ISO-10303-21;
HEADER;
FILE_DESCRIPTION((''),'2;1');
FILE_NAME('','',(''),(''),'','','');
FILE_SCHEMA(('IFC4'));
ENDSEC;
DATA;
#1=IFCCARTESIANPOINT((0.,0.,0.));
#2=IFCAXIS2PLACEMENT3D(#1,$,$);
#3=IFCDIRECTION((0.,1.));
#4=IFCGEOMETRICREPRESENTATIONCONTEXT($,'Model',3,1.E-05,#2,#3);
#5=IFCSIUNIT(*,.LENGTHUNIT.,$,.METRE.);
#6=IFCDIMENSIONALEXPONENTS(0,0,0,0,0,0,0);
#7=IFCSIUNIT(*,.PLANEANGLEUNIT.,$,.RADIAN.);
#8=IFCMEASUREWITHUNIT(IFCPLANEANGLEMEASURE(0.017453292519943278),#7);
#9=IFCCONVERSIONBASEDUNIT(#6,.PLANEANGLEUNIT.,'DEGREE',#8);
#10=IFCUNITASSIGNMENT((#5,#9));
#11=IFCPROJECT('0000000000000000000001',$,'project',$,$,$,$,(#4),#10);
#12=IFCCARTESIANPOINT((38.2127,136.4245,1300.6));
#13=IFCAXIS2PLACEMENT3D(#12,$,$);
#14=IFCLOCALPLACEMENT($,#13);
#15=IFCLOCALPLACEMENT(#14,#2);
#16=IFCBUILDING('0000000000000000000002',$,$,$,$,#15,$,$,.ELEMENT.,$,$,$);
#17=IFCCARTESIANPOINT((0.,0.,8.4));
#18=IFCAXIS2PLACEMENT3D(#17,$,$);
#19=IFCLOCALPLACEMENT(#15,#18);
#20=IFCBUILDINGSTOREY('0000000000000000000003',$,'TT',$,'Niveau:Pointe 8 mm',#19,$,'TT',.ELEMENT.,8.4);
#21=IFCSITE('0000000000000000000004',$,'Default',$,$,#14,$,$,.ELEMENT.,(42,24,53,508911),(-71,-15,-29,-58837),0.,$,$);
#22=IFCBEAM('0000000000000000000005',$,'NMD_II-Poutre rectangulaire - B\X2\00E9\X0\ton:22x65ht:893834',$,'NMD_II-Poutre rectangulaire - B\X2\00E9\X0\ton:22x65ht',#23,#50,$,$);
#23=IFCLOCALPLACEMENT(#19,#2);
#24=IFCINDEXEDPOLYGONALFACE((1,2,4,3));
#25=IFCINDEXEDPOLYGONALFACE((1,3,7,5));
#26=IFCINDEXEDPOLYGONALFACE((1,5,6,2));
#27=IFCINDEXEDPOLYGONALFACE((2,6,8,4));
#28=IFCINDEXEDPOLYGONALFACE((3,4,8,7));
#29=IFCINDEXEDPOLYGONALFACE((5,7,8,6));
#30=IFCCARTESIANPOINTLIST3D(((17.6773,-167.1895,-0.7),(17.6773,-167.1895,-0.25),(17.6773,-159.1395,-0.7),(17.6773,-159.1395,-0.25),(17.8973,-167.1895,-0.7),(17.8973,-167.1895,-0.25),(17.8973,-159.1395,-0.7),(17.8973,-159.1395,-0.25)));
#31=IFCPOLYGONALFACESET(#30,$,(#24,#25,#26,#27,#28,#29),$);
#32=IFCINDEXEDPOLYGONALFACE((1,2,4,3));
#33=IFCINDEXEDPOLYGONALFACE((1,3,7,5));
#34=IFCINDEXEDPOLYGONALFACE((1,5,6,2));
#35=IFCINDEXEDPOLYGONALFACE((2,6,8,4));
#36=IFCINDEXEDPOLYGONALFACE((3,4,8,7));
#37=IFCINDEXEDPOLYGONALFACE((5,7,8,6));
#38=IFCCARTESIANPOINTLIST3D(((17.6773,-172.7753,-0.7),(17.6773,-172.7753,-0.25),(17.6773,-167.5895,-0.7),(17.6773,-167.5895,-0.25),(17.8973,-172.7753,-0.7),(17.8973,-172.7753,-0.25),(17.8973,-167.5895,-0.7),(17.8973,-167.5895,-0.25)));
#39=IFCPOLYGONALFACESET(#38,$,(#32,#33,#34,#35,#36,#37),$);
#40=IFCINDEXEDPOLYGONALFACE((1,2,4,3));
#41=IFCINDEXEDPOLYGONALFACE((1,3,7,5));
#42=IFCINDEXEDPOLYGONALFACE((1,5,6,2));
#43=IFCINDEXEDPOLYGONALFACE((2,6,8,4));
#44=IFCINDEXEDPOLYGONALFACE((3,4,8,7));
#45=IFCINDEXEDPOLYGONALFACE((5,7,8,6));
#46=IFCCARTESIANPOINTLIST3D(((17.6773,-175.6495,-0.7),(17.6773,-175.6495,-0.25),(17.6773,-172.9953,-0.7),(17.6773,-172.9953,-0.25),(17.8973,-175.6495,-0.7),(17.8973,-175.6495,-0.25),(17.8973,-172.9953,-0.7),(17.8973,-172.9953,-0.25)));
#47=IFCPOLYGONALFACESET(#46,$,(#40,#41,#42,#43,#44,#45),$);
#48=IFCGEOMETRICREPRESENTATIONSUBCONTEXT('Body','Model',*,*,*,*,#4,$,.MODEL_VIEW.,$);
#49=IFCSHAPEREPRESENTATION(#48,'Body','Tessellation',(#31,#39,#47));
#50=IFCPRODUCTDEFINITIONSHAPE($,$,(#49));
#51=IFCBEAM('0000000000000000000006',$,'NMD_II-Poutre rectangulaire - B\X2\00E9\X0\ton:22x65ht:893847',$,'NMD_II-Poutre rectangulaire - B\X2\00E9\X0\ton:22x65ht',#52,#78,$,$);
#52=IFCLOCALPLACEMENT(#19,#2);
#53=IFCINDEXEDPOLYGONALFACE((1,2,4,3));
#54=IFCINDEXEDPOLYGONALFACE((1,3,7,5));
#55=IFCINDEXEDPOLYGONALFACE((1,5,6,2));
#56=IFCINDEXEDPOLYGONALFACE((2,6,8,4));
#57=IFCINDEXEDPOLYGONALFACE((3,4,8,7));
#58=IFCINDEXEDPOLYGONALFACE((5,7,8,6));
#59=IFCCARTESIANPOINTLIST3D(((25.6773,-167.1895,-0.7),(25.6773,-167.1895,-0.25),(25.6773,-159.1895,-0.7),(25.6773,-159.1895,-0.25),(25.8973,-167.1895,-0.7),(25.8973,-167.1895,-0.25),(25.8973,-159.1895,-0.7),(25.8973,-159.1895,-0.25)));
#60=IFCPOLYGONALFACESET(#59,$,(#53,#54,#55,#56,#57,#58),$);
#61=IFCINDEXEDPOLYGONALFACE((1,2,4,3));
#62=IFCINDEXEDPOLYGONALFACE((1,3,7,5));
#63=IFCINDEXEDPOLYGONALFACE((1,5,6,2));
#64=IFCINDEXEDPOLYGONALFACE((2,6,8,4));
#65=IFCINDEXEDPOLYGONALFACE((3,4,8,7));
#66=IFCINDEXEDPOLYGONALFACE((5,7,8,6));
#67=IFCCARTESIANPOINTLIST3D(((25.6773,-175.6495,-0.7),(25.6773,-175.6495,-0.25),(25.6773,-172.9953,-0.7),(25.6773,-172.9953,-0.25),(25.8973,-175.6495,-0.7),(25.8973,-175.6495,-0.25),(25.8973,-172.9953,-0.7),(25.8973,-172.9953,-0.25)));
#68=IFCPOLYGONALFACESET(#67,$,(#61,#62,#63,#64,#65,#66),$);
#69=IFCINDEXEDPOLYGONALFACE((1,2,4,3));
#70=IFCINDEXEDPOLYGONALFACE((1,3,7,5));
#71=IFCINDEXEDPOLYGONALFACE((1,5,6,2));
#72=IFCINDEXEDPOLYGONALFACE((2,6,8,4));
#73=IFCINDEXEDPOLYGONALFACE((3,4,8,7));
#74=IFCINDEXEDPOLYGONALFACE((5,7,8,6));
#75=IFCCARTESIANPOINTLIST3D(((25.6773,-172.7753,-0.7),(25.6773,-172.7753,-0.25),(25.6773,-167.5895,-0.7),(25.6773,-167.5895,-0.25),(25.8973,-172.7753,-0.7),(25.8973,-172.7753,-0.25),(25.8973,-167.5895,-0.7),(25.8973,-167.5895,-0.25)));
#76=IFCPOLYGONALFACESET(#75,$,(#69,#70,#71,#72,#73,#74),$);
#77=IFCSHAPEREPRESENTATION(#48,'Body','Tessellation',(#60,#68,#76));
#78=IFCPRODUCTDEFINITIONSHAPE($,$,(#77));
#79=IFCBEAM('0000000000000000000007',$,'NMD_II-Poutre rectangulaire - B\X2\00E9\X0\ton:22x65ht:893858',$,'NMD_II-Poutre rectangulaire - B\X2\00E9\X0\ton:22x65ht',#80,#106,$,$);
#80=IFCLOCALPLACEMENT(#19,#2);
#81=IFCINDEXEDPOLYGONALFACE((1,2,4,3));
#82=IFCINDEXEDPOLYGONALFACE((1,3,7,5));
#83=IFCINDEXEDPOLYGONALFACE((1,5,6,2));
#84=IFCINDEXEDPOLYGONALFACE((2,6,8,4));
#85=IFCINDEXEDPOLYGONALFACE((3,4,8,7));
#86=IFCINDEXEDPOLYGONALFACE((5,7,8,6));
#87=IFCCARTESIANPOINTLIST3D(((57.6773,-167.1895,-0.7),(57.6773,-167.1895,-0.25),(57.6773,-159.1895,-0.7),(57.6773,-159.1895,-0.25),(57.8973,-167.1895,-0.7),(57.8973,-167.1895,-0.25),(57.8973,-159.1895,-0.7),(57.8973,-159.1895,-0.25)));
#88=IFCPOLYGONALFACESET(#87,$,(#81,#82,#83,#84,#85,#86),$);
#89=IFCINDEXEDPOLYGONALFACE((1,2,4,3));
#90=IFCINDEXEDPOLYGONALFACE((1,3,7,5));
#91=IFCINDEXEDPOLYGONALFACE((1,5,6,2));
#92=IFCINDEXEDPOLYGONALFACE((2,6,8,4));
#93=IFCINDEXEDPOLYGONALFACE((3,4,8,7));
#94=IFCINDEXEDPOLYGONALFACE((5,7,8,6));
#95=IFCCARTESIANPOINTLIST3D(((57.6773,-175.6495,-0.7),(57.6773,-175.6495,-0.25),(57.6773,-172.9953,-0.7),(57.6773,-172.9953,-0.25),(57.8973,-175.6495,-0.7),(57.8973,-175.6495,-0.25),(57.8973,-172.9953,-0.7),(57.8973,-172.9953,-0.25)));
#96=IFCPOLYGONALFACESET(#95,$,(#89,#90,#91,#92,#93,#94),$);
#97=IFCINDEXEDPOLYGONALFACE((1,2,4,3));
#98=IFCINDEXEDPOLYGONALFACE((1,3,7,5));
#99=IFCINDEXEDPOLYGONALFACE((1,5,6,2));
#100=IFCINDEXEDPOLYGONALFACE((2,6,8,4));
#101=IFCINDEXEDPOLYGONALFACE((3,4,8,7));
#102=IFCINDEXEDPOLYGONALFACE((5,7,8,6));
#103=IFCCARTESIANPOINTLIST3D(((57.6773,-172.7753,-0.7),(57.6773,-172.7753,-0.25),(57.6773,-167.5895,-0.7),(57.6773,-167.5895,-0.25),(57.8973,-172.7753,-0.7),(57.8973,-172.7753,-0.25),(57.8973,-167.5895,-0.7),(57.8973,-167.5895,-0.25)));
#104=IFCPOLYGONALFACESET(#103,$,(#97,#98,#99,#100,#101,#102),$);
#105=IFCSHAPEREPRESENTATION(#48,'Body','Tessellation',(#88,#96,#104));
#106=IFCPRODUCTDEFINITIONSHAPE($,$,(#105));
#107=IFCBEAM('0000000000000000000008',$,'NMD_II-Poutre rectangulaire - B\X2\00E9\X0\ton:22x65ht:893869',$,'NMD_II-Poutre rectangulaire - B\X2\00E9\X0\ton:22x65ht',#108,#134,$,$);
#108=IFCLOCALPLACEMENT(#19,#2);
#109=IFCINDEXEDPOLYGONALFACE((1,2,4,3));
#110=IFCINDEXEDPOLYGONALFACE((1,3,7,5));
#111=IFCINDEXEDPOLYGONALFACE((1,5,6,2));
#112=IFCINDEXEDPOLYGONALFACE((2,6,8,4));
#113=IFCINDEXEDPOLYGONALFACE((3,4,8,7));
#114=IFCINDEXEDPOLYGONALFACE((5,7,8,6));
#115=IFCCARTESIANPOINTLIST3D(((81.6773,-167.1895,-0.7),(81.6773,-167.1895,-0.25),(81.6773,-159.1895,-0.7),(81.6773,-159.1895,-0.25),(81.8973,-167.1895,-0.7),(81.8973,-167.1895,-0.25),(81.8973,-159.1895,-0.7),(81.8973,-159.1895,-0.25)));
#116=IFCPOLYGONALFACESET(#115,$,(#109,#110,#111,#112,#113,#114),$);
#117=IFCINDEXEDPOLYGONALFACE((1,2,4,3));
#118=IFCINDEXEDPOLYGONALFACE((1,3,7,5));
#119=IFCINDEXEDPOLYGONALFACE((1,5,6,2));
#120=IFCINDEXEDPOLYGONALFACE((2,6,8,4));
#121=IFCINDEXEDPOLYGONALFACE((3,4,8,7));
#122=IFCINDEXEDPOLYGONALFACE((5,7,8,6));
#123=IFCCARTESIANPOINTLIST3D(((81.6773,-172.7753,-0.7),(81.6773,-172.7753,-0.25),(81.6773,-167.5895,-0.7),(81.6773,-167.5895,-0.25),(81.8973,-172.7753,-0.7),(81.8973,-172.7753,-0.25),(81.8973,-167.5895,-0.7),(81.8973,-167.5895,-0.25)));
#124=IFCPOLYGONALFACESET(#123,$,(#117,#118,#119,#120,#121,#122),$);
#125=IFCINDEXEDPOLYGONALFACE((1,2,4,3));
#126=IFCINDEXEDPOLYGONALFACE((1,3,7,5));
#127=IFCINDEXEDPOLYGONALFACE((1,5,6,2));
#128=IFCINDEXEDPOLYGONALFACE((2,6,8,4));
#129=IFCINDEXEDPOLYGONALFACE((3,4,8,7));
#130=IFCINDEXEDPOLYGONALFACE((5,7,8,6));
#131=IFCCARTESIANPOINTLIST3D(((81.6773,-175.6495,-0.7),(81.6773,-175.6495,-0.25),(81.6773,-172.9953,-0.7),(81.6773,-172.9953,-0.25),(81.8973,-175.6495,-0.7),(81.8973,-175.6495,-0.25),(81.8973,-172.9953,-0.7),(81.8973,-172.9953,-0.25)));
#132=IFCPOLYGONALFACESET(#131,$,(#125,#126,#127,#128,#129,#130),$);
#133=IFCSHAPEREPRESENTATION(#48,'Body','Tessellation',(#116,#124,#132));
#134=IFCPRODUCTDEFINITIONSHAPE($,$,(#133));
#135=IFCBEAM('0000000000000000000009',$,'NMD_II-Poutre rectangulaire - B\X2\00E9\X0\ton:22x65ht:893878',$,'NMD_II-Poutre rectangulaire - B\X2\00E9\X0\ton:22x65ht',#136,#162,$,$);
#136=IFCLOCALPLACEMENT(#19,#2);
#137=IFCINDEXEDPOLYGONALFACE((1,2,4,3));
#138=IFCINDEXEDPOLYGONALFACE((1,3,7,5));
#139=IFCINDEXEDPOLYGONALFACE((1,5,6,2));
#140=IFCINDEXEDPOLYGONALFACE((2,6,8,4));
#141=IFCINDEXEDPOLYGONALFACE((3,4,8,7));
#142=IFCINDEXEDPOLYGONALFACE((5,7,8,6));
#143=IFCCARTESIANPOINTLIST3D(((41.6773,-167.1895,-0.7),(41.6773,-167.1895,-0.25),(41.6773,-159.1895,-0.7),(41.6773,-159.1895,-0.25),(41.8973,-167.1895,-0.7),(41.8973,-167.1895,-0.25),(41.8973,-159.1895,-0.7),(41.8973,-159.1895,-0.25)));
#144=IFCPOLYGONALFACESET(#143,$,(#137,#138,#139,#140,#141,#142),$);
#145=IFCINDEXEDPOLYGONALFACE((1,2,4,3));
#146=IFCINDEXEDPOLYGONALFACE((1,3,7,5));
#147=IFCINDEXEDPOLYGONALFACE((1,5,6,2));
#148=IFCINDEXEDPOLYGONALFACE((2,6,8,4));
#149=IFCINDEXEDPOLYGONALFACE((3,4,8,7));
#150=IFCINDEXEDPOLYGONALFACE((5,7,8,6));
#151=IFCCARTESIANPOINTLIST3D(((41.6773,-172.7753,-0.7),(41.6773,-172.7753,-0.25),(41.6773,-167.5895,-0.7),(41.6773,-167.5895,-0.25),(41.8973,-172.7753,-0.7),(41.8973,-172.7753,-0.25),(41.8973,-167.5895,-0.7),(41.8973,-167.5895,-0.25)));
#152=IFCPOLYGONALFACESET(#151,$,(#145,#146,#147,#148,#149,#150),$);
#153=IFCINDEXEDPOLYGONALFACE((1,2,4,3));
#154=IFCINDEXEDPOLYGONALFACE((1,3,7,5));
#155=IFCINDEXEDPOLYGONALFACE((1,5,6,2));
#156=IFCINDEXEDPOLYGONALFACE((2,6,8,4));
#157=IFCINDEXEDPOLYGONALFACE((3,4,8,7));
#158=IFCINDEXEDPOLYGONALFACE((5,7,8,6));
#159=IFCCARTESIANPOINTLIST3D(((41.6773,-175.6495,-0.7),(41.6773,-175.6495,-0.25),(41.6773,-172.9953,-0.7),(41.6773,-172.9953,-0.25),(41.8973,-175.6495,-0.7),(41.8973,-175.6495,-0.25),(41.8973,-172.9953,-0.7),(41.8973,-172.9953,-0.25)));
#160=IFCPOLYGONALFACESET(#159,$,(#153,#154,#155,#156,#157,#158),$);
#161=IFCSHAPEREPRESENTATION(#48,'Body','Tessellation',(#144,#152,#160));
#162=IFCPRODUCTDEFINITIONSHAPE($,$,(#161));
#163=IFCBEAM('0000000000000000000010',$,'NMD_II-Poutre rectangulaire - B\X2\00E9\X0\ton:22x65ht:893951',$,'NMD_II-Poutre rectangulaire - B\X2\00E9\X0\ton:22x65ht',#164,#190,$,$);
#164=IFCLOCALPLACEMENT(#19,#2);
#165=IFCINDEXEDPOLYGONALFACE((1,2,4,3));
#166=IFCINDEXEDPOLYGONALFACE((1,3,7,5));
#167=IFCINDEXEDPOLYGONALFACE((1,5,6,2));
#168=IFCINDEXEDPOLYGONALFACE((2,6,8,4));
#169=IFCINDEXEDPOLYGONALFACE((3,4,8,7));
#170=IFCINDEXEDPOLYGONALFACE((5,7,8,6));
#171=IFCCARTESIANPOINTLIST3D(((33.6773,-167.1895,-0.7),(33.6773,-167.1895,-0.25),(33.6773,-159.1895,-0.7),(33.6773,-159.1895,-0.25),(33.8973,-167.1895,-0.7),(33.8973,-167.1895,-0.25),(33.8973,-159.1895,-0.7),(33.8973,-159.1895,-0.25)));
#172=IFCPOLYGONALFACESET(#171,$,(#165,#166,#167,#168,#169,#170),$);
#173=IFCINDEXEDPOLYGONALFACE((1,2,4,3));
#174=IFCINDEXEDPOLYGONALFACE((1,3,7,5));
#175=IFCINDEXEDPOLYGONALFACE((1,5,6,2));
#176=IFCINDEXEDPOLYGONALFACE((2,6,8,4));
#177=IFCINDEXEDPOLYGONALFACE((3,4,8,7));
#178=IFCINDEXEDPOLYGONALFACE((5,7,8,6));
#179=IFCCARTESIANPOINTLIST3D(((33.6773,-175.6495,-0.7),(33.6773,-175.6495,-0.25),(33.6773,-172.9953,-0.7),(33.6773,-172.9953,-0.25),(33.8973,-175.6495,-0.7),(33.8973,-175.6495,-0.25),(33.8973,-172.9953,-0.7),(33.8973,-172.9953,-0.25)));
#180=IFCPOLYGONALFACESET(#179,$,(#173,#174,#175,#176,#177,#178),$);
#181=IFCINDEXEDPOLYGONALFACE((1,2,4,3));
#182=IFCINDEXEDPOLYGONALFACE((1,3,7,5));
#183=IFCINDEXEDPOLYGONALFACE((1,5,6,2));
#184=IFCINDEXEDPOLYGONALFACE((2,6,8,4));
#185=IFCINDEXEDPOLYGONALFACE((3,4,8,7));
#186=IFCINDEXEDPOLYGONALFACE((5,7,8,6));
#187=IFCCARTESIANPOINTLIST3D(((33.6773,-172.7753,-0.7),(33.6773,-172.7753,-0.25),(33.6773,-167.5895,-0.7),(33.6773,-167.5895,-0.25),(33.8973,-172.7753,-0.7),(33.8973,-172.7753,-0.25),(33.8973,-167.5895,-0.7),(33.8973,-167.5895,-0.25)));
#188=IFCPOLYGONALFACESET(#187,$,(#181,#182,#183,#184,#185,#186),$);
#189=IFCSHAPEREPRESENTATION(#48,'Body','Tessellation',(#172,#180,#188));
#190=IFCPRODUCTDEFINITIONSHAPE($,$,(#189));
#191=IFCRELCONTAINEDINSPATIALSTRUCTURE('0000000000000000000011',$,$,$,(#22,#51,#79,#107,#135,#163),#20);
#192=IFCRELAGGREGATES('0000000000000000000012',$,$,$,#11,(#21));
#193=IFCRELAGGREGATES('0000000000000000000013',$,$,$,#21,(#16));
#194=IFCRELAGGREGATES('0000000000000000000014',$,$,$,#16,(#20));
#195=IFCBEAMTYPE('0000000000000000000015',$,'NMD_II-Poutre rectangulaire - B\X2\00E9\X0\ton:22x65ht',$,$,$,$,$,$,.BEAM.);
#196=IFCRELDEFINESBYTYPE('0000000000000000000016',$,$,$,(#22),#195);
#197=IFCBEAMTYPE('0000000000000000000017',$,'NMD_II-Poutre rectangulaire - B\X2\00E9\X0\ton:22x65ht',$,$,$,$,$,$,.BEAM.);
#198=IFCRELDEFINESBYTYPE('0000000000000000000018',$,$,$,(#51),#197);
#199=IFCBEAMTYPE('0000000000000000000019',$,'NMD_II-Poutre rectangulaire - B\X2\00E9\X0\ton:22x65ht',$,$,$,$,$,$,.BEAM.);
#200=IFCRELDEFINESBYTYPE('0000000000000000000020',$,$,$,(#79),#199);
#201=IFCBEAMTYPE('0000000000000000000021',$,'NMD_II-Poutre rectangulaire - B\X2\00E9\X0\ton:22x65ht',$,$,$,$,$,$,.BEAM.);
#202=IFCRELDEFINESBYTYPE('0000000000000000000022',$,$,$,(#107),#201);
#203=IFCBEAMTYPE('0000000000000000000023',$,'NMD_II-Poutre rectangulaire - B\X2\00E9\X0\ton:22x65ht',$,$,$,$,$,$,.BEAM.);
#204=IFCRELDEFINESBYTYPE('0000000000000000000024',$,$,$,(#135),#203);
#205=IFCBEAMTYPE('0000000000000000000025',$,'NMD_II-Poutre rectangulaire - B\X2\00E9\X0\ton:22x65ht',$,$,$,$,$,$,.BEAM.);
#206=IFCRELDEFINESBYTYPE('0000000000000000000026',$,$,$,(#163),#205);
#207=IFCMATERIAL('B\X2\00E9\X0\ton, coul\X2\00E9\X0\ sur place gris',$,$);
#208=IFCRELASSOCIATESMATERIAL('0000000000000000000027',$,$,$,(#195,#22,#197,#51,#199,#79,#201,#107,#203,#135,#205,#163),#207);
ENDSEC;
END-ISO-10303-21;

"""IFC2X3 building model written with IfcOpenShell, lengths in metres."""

from ifc_helpers import new_model, entity, si_unit, converted_unit, direction, frame, frame_2d, origin, place, context, subcontext, project, spatial, rectangle, extrude, source, transform, mapped, material, type_object, type_shapes, element, save


model = new_model("IFC2X3")

# Units and contexts
model_context = context("Model", 3, precision=1e-05, world=origin(), true_north=direction((0.0, 1.0)))
body_context = subcontext(model_context, "Body", "Model", "MODEL_VIEW")
ifc_project = project(units=[si_unit("LENGTHUNIT", "METRE"), converted_unit("PLANEANGLEUNIT", "DEGREE", entity("IfcPlaneAngleMeasure", 0.017453292519943278), si_unit("PLANEANGLEUNIT", "RADIAN"), dimensions=[0, 0, 0, 0, 0, 0, 0])], contexts=[model_context])

# Site, building, storey
site_placement = place(None, frame((38.2127, 136.4245, 1300.6)))
site = spatial("IfcSite", under=ifc_project, at=site_placement, Name="Default", CompositionType="ELEMENT", RefLatitude=(42, 24, 53, 508911), RefLongitude=(-71, -15, -29, -58837), RefElevation=0.0)
building_placement = place(site_placement, origin())
building = spatial("IfcBuilding", under=site, at=building_placement, CompositionType="ELEMENT")
storey_placement = place(building_placement, frame((0.0, 0.0, 8.4)))
storey = spatial("IfcBuildingStorey", under=building, at=storey_placement, Name="TT", ObjectType="Niveau:Pointe 8 mm", LongName="TT", CompositionType="ELEMENT", Elevation=8.4)

# Beams
ifc_material_1 = material(Name="Béton, coulé sur place gris")
beam_type_1 = type_object("IfcBeamType", Name="NMD_II-Poutre rectangulaire - Béton:22x65ht", PredefinedType="BEAM", material=ifc_material_1)
shared_shape_1 = source(origin(), body_context, "Body", "SweptSolid", [
    extrude(rectangle(XDim=0.45, YDim=0.22, at=frame_2d((0.0, 0.0), x_axis=(0.0, 1.0))), frame((17.7873, -167.1895, 7.925), z_axis=(0.0, 1.0, 0.0), x_axis=(-1.0, 0.0, 0.0)), (0.0, 0.0, 1.0), 8.05),
    extrude(rectangle(XDim=0.45, YDim=0.22, at=frame_2d((0.0, 0.0), x_axis=(0.0, 1.0))), frame((17.7873, -172.7753, 7.925), z_axis=(0.0, 1.0, 0.0), x_axis=(-1.0, 0.0, 0.0)), (0.0, 0.0, 1.0), 5.1859),
    extrude(rectangle(XDim=0.45, YDim=0.22, at=frame_2d((0.0, 0.0), x_axis=(0.0, 1.0))), frame((17.7873, -175.6495, 7.925), z_axis=(0.0, 1.0, 0.0), x_axis=(-1.0, 0.0, 0.0)), (0.0, 0.0, 1.0), 2.6541),
])
type_shapes(beam_type_1, [shared_shape_1])
beam_1_placement = place(storey_placement, frame((0.0, 0.0, -8.4)))
element("IfcBeam", 1, at=beam_1_placement, inside=storey, type_object=beam_type_1, material=ifc_material_1, Name="NMD_II-Poutre rectangulaire - Béton:22x65ht:893834", ObjectType="NMD_II-Poutre rectangulaire - Béton:22x65ht", context=body_context, shape_type="MappedRepresentation", body=[
    mapped(shared_shape_1, transform((0.0, 0.0, 0.0), scale=1.0)),
])
beam_type_2 = type_object("IfcBeamType", Name="NMD_II-Poutre rectangulaire - Béton:22x65ht", PredefinedType="BEAM", material=ifc_material_1)
shared_shape_2 = source(origin(), body_context, "Body", "SweptSolid", [
    extrude(rectangle(XDim=0.45, YDim=0.22, at=frame_2d((0.0, 0.0), x_axis=(0.0, 1.0))), frame((25.7873, -167.1895, 7.925), z_axis=(0.0, 1.0, 0.0), x_axis=(-1.0, 0.0, 0.0)), (0.0, 0.0, 1.0), 8.0),
    extrude(rectangle(XDim=0.45, YDim=0.22, at=frame_2d((0.0, 0.0), x_axis=(0.0, 1.0))), frame((25.7873, -175.6495, 7.925), z_axis=(0.0, 1.0, 0.0), x_axis=(-1.0, 0.0, 0.0)), (0.0, 0.0, 1.0), 2.6541),
    extrude(rectangle(XDim=0.45, YDim=0.22, at=frame_2d((0.0, 0.0), x_axis=(0.0, 1.0))), frame((25.7873, -172.7753, 7.925), z_axis=(0.0, 1.0, 0.0), x_axis=(-1.0, 0.0, 0.0)), (0.0, 0.0, 1.0), 5.1859),
])
type_shapes(beam_type_2, [shared_shape_2])
beam_2_placement = place(storey_placement, frame((0.0, 0.0, -8.4)))
element("IfcBeam", 2, at=beam_2_placement, inside=storey, type_object=beam_type_2, material=ifc_material_1, Name="NMD_II-Poutre rectangulaire - Béton:22x65ht:893847", ObjectType="NMD_II-Poutre rectangulaire - Béton:22x65ht", context=body_context, shape_type="MappedRepresentation", body=[
    mapped(shared_shape_2, transform((0.0, 0.0, 0.0), scale=1.0)),
])
beam_type_3 = type_object("IfcBeamType", Name="NMD_II-Poutre rectangulaire - Béton:22x65ht", PredefinedType="BEAM", material=ifc_material_1)
shared_shape_3 = source(origin(), body_context, "Body", "SweptSolid", [
    extrude(rectangle(XDim=0.45, YDim=0.22, at=frame_2d((0.0, 0.0), x_axis=(0.0, 1.0))), frame((57.7873, -167.1895, 7.925), z_axis=(0.0, 1.0, 0.0), x_axis=(-1.0, 0.0, 0.0)), (0.0, 0.0, 1.0), 8.0),
    extrude(rectangle(XDim=0.45, YDim=0.22, at=frame_2d((0.0, 0.0), x_axis=(0.0, 1.0))), frame((57.7873, -175.6495, 7.925), z_axis=(0.0, 1.0, 0.0), x_axis=(-1.0, 0.0, 0.0)), (0.0, 0.0, 1.0), 2.6541),
    extrude(rectangle(XDim=0.45, YDim=0.22, at=frame_2d((0.0, 0.0), x_axis=(0.0, 1.0))), frame((57.7873, -172.7753, 7.925), z_axis=(0.0, 1.0, 0.0), x_axis=(-1.0, 0.0, 0.0)), (0.0, 0.0, 1.0), 5.1859),
])
type_shapes(beam_type_3, [shared_shape_3])
beam_3_placement = place(storey_placement, frame((0.0, 0.0, -8.4)))
element("IfcBeam", 3, at=beam_3_placement, inside=storey, type_object=beam_type_3, material=ifc_material_1, Name="NMD_II-Poutre rectangulaire - Béton:22x65ht:893858", ObjectType="NMD_II-Poutre rectangulaire - Béton:22x65ht", context=body_context, shape_type="MappedRepresentation", body=[
    mapped(shared_shape_3, transform((0.0, 0.0, 0.0), scale=1.0)),
])
beam_type_4 = type_object("IfcBeamType", Name="NMD_II-Poutre rectangulaire - Béton:22x65ht", PredefinedType="BEAM", material=ifc_material_1)
shared_shape_4 = source(origin(), body_context, "Body", "SweptSolid", [
    extrude(rectangle(XDim=0.45, YDim=0.22, at=frame_2d((0.0, 0.0), x_axis=(0.0, 1.0))), frame((81.7873, -167.1895, 7.925), z_axis=(0.0, 1.0, 0.0), x_axis=(-1.0, 0.0, 0.0)), (0.0, 0.0, 1.0), 8.0),
    extrude(rectangle(XDim=0.45, YDim=0.22, at=frame_2d((0.0, 0.0), x_axis=(0.0, 1.0))), frame((81.7873, -172.7753, 7.925), z_axis=(0.0, 1.0, 0.0), x_axis=(-1.0, 0.0, 0.0)), (0.0, 0.0, 1.0), 5.1859),
    extrude(rectangle(XDim=0.45, YDim=0.22, at=frame_2d((0.0, 0.0), x_axis=(0.0, 1.0))), frame((81.7873, -175.6495, 7.925), z_axis=(0.0, 1.0, 0.0), x_axis=(-1.0, 0.0, 0.0)), (0.0, 0.0, 1.0), 2.6541),
])
type_shapes(beam_type_4, [shared_shape_4])
beam_4_placement = place(storey_placement, frame((0.0, 0.0, -8.4)))
element("IfcBeam", 4, at=beam_4_placement, inside=storey, type_object=beam_type_4, material=ifc_material_1, Name="NMD_II-Poutre rectangulaire - Béton:22x65ht:893869", ObjectType="NMD_II-Poutre rectangulaire - Béton:22x65ht", context=body_context, shape_type="MappedRepresentation", body=[
    mapped(shared_shape_4, transform((0.0, 0.0, 0.0), scale=1.0)),
])
beam_type_5 = type_object("IfcBeamType", Name="NMD_II-Poutre rectangulaire - Béton:22x65ht", PredefinedType="BEAM", material=ifc_material_1)
shared_shape_5 = source(origin(), body_context, "Body", "SweptSolid", [
    extrude(rectangle(XDim=0.45, YDim=0.22, at=frame_2d((0.0, 0.0), x_axis=(0.0, 1.0))), frame((41.7873, -167.1895, 7.925), z_axis=(0.0, 1.0, 0.0), x_axis=(-1.0, 0.0, 0.0)), (0.0, 0.0, 1.0), 8.0),
    extrude(rectangle(XDim=0.45, YDim=0.22, at=frame_2d((0.0, 0.0), x_axis=(0.0, 1.0))), frame((41.7873, -172.7753, 7.925), z_axis=(0.0, 1.0, 0.0), x_axis=(-1.0, 0.0, 0.0)), (0.0, 0.0, 1.0), 5.1859),
    extrude(rectangle(XDim=0.45, YDim=0.22, at=frame_2d((0.0, 0.0), x_axis=(0.0, 1.0))), frame((41.7873, -175.6495, 7.925), z_axis=(0.0, 1.0, 0.0), x_axis=(-1.0, 0.0, 0.0)), (0.0, 0.0, 1.0), 2.6541),
])
type_shapes(beam_type_5, [shared_shape_5])
beam_5_placement = place(storey_placement, frame((0.0, 0.0, -8.4)))
element("IfcBeam", 5, at=beam_5_placement, inside=storey, type_object=beam_type_5, material=ifc_material_1, Name="NMD_II-Poutre rectangulaire - Béton:22x65ht:893878", ObjectType="NMD_II-Poutre rectangulaire - Béton:22x65ht", context=body_context, shape_type="MappedRepresentation", body=[
    mapped(shared_shape_5, transform((0.0, 0.0, 0.0), scale=1.0)),
])
beam_type_6 = type_object("IfcBeamType", Name="NMD_II-Poutre rectangulaire - Béton:22x65ht", PredefinedType="BEAM", material=ifc_material_1)
shared_shape_6 = source(origin(), body_context, "Body", "SweptSolid", [
    extrude(rectangle(XDim=0.45, YDim=0.22, at=frame_2d((0.0, 0.0), x_axis=(0.0, 1.0))), frame((33.7873, -167.1895, 7.925), z_axis=(0.0, 1.0, 0.0), x_axis=(-1.0, 0.0, 0.0)), (0.0, 0.0, 1.0), 8.0),
    extrude(rectangle(XDim=0.45, YDim=0.22, at=frame_2d((0.0, 0.0), x_axis=(0.0, 1.0))), frame((33.7873, -175.6495, 7.925), z_axis=(0.0, 1.0, 0.0), x_axis=(-1.0, 0.0, 0.0)), (0.0, 0.0, 1.0), 2.6541),
    extrude(rectangle(XDim=0.45, YDim=0.22, at=frame_2d((0.0, 0.0), x_axis=(0.0, 1.0))), frame((33.7873, -172.7753, 7.925), z_axis=(0.0, 1.0, 0.0), x_axis=(-1.0, 0.0, 0.0)), (0.0, 0.0, 1.0), 5.1859),
])
type_shapes(beam_type_6, [shared_shape_6])
beam_6_placement = place(storey_placement, frame((0.0, 0.0, -8.4)))
element("IfcBeam", 6, at=beam_6_placement, inside=storey, type_object=beam_type_6, material=ifc_material_1, Name="NMD_II-Poutre rectangulaire - Béton:22x65ht:893951", ObjectType="NMD_II-Poutre rectangulaire - Béton:22x65ht", context=body_context, shape_type="MappedRepresentation", body=[
    mapped(shared_shape_6, transform((0.0, 0.0, 0.0), scale=1.0)),
])

save(model, "model.ifc")
